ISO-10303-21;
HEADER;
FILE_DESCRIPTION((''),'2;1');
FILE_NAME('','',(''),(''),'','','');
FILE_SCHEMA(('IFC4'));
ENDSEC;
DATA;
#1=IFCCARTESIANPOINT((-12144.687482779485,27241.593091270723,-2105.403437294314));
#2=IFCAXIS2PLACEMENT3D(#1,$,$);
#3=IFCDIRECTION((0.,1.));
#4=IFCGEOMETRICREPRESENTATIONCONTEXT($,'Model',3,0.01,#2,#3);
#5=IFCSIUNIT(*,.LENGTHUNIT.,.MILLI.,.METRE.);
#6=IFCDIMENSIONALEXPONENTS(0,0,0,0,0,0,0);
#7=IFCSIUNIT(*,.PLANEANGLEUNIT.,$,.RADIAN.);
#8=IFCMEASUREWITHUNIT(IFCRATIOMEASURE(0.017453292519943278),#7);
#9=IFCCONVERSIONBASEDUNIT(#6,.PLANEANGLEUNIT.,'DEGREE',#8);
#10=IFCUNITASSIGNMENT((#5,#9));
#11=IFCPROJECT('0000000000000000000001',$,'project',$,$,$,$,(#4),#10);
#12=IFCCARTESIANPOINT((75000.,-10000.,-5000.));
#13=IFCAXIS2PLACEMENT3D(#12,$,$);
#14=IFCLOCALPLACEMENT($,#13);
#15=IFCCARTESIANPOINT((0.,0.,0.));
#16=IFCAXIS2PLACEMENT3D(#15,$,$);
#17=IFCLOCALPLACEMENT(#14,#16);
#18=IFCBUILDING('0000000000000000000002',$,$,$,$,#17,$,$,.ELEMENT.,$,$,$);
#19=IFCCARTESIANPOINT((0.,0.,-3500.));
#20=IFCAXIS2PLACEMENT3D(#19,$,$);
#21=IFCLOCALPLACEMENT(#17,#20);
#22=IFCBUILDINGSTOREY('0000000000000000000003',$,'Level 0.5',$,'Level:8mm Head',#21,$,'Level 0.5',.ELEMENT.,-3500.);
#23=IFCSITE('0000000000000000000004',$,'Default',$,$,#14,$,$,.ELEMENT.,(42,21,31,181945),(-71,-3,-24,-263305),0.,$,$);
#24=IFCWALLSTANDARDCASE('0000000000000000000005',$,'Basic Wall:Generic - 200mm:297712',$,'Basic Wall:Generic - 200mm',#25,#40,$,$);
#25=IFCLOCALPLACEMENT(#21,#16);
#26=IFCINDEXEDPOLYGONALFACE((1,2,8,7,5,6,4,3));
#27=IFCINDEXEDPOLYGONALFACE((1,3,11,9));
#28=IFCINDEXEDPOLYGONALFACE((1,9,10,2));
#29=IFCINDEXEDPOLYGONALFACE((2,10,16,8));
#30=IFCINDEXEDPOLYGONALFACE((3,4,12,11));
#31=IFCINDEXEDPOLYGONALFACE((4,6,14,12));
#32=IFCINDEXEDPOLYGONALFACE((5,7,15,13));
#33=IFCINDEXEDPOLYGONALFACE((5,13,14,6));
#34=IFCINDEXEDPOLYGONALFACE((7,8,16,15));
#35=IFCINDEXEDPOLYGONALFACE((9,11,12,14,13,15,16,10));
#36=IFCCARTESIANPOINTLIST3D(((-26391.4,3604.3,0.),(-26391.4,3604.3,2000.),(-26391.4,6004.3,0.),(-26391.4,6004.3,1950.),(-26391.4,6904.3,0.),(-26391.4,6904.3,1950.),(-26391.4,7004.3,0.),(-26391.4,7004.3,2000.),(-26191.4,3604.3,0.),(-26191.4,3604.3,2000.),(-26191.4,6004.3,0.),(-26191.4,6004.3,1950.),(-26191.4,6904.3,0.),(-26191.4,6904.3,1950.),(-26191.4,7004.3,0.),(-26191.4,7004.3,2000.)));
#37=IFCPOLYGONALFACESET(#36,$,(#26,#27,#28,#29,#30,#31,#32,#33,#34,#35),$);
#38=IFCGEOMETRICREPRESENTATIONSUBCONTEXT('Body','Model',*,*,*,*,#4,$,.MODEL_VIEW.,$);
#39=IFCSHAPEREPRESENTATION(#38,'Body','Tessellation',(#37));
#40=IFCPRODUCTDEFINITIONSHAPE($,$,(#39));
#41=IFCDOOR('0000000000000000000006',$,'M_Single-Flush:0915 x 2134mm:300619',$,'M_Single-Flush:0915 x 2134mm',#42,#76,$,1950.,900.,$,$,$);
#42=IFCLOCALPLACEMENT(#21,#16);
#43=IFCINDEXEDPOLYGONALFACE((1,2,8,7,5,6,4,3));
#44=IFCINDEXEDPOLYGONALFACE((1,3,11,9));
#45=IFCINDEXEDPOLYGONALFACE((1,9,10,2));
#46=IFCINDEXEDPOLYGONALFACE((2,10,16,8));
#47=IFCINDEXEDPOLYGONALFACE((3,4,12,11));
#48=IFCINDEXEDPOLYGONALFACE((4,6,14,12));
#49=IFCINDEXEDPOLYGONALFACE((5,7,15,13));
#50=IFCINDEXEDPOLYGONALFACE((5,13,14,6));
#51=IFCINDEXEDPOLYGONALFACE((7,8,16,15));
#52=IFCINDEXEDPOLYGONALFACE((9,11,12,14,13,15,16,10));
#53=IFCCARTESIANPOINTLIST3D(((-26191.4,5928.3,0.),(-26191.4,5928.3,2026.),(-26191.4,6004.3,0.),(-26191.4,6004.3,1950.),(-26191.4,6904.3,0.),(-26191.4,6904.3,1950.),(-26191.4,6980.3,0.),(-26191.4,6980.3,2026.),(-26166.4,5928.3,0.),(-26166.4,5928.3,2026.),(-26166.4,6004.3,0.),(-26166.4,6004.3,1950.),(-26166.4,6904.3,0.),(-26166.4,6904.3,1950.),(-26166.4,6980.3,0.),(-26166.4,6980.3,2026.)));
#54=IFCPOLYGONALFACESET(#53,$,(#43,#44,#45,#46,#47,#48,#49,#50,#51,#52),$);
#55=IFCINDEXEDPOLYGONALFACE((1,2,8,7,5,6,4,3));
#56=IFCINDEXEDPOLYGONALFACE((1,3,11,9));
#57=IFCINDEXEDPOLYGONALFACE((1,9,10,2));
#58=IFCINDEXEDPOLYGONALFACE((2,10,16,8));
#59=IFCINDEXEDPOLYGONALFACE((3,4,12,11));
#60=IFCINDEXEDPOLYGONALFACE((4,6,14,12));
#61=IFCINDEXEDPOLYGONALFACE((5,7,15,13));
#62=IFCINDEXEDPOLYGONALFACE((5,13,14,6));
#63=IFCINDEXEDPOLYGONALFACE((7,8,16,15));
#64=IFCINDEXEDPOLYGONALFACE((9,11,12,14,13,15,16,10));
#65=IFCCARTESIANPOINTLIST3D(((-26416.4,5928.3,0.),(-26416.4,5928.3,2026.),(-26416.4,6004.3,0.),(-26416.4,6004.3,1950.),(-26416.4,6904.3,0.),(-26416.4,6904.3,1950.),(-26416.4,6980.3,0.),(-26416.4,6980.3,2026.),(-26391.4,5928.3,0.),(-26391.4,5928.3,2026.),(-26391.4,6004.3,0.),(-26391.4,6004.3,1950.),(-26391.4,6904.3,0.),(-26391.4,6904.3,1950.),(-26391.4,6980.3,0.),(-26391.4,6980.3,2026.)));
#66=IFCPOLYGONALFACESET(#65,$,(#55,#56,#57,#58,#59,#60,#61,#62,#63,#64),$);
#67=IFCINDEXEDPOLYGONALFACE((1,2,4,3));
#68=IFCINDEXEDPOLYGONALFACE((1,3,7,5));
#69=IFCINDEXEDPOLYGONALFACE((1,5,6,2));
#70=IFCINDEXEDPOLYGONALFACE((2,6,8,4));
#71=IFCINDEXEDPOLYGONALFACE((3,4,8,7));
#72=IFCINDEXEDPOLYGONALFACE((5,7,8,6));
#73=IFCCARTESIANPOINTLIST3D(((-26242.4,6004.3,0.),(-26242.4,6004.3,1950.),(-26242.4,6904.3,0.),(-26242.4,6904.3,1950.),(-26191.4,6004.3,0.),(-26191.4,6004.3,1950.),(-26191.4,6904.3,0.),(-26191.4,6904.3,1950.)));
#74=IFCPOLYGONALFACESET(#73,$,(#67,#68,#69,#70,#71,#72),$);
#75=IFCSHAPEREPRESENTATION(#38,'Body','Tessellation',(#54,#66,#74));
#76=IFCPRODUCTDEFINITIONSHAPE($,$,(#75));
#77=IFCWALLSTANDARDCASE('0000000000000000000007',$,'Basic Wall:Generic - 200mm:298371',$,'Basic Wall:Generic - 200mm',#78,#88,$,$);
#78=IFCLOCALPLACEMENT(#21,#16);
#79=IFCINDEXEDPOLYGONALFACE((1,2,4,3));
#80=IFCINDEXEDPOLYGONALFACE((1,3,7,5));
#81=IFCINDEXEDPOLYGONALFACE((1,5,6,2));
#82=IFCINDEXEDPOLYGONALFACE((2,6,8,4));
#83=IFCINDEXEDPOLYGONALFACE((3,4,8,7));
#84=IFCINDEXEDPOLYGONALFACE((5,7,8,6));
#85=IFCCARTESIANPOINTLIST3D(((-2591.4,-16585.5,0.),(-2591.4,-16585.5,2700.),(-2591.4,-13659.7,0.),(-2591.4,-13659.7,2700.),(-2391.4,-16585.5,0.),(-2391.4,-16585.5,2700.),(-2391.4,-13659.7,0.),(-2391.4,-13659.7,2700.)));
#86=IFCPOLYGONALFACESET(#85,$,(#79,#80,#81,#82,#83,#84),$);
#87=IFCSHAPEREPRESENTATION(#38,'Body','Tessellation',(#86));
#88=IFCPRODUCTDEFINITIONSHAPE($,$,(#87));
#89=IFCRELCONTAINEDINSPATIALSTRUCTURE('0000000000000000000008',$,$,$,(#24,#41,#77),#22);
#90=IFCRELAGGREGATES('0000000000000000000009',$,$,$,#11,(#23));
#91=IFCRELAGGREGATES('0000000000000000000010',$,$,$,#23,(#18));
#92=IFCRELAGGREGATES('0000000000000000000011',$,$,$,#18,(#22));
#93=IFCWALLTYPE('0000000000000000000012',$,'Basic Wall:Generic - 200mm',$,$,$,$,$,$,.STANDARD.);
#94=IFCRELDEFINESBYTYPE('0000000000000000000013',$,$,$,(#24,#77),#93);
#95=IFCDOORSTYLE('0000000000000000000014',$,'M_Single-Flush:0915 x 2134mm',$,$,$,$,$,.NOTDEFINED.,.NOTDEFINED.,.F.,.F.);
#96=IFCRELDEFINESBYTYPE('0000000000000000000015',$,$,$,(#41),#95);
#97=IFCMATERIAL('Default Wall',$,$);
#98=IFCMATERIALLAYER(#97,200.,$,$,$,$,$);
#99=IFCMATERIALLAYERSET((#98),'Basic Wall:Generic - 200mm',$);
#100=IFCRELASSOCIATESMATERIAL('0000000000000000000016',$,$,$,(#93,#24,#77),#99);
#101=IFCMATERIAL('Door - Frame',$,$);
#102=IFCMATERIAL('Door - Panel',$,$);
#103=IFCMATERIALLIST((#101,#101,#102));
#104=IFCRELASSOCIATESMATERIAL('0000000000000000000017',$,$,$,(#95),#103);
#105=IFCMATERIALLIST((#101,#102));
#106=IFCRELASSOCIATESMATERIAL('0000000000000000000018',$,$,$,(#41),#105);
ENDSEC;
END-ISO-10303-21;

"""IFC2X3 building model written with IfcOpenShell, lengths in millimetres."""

from ifc_helpers import new_model, entity, si_unit, converted_unit, direction, frame, frame_2d, origin, place, context, subcontext, project, spatial, polyline, rectangle, outline, extrude, clip, bounded_halfspace, source, transform, mapped, material, material_list, layer, layer_set, layer_usage, type_object, type_shapes, element, fill, save


model = new_model("IFC2X3")

# Units and contexts
model_context = context("Model", 3, precision=0.01, world=frame((-12144.687482779485, 27241.593091270723, -2105.403437294314)), true_north=direction((0.0, 1.0)))
body_context = subcontext(model_context, "Body", "Model", "MODEL_VIEW")
ifc_project = project(units=[si_unit("LENGTHUNIT", "METRE", prefix="MILLI"), converted_unit("PLANEANGLEUNIT", "DEGREE", entity("IfcRatioMeasure", 0.017453292519943278), si_unit("PLANEANGLEUNIT", "RADIAN"), dimensions=[0, 0, 0, 0, 0, 0, 0])], contexts=[model_context])

# Site, building, storey
site_placement = place(None, frame((75000.0, -10000.0, -5000.0)))
site = spatial("IfcSite", under=ifc_project, at=site_placement, Name="Default", CompositionType="ELEMENT", RefLatitude=(42, 21, 31, 181945), RefLongitude=(-71, -3, -24, -263305), RefElevation=0.0)
building_placement = place(site_placement, origin())
building = spatial("IfcBuilding", under=site, at=building_placement, CompositionType="ELEMENT")
storey_placement = place(building_placement, frame((0.0, 0.0, -3500.0)))
storey = spatial("IfcBuildingStorey", under=building, at=storey_placement, Name="Level 0.5", ObjectType="Level:8mm Head", LongName="Level 0.5", CompositionType="ELEMENT", Elevation=-3500.0)

# Shared definitions
ifc_material_1 = material(Name="Default Wall")
ifc_layer_1 = layer(ifc_material_1, 200.0)
ifc_layer_set_1 = layer_set([ifc_layer_1], Name="Basic Wall:Generic - 200mm")
wall_type_1 = type_object("IfcWallType", Name="Basic Wall:Generic - 200mm", PredefinedType="STANDARD", material=ifc_layer_set_1)

# Wall, opening, door
ifc_layer_usage_1 = layer_usage(ifc_layer_set_1, "AXIS2", "NEGATIVE", 100.0)
wall_1_placement = place(storey_placement, frame((-26291.4, 3604.3, 0.0), z_axis=(0.0, 0.0, 1.0), x_axis=(0.0, 1.0, 0.0)))
wall_1 = element("IfcWallStandardCase", 1, at=wall_1_placement, inside=storey, type_object=wall_type_1, material=ifc_layer_usage_1, Name="Basic Wall:Generic - 200mm:297712", ObjectType="Basic Wall:Generic - 200mm", context=body_context, shape_type="Clipping", body=[
    clip(extrude(rectangle(XDim=3400.0, YDim=200.0, at=frame_2d((1700.0, 0.0), x_axis=(1.0, 0.0))), origin(), (0.0, 0.0, 1.0), 2000.0), bounded_halfspace(frame((0.0, -100.0, 2000.0), z_axis=(0.0, 0.0, -1.0), x_axis=(0.0, -1.0, 0.0)), True, frame((0.0, -100.0, 2000.0)), polyline([(0.0, 0.0), (1036320.0, 0.0), (1036320.0, 60960.0), (0.0, 60960.0), (0.0, 0.0)]))),
])
opening_1_placement = place(wall_1_placement, frame((3300.0, 100.0, 0.0)))
opening_1 = element("IfcOpeningElement", 2, at=opening_1_placement, cuts=wall_1, ObjectType="Opening", context=body_context, shape_type="SweptSolid", body=[
    extrude(rectangle(XDim=900.0, YDim=1950.0, at=frame_2d((975.0, 450.0), x_axis=(0.0, -1.0))), frame((0.0, 0.0, 0.0), z_axis=(0.0, -1.0, 0.0), x_axis=(0.0, 0.0, 1.0)), (0.0, 0.0, 1.0), 200.0),
])
ifc_material_2 = material(Name="Door - Frame")
ifc_material_3 = material(Name="Door - Panel")
ifc_material_list_1 = material_list([ifc_material_2, ifc_material_3])
ifc_material_list_2 = material_list([ifc_material_2, ifc_material_2, ifc_material_3])
door_style_1 = type_object("IfcDoorStyle", Name="M_Single-Flush:0915 x 2134mm", ConstructionType="NOTDEFINED", OperationType="NOTDEFINED", ParameterTakesPrecedence=False, Sizeable=False, material=ifc_material_list_2)
shared_shape_1 = source(origin(), body_context, "Body", "SweptSolid", [
    extrude(outline(polyline([(-526.0, -1032.0), (526.0, -1032.0), (526.0, 994.0), (450.0, 994.0), (450.0, -956.0), (-450.0, -956.0), (-450.0, 994.0), (-526.0, 994.0), (-526.0, -1032.0)])), frame((450.0, 225.0, 994.0), z_axis=(0.0, -1.0, 0.0), x_axis=(-1.0, 0.0, 0.0)), (0.0, 0.0, 1.0), 25.0),
    extrude(outline(polyline([(-1032.0, -526.0), (994.0, -526.0), (994.0, -450.0), (-956.0, -450.0), (-956.0, 450.0), (994.0, 450.0), (994.0, 526.0), (-1032.0, 526.0), (-1032.0, -526.0)])), frame((450.0, 0.0, 994.0), z_axis=(0.0, -1.0, 0.0), x_axis=(0.0, 0.0, -1.0)), (0.0, 0.0, 1.0), 25.0),
    extrude(rectangle(XDim=900.0, YDim=51.0, at=frame_2d((0.0, 0.0), x_axis=(1.0, 0.0))), frame((450.0, 174.5, 0.0)), (0.0, 0.0, 1.0), 1950.0),
])
type_shapes(door_style_1, [shared_shape_1])
door_1_placement = place(opening_1_placement, frame((0.0, 0.0, 0.0), z_axis=(0.0, 0.0, 1.0), x_axis=(-1.0, 0.0, 0.0)))
door_1 = element("IfcDoor", 3, at=door_1_placement, inside=storey, type_object=door_style_1, material=ifc_material_list_1, Name="M_Single-Flush:0915 x 2134mm:300619", ObjectType="M_Single-Flush:0915 x 2134mm", OverallHeight=1950.0, OverallWidth=900.0, context=body_context, shape_type="MappedRepresentation", body=[
    mapped(shared_shape_1, transform((0.0, 0.0, 0.0), scale=1.0)),
])
fill(opening_1, door_1)

# Wall
ifc_layer_usage_2 = layer_usage(ifc_layer_set_1, "AXIS2", "NEGATIVE", 100.0)
wall_2_placement = place(storey_placement, frame((-2491.4, -16585.5, 0.0), z_axis=(0.0, 0.0, 1.0), x_axis=(0.0, 1.0, 0.0)))
element("IfcWallStandardCase", 4, at=wall_2_placement, inside=storey, type_object=wall_type_1, material=ifc_layer_usage_2, Name="Basic Wall:Generic - 200mm:298371", ObjectType="Basic Wall:Generic - 200mm", context=body_context, shape_type="SweptSolid", body=[
    extrude(rectangle(XDim=2925.8, YDim=200.0, at=frame_2d((1462.9, 0.0), x_axis=(-1.0, 0.0))), origin(), (0.0, 0.0, 1.0), 2700.0),
])

save(model, "model.ifc")
